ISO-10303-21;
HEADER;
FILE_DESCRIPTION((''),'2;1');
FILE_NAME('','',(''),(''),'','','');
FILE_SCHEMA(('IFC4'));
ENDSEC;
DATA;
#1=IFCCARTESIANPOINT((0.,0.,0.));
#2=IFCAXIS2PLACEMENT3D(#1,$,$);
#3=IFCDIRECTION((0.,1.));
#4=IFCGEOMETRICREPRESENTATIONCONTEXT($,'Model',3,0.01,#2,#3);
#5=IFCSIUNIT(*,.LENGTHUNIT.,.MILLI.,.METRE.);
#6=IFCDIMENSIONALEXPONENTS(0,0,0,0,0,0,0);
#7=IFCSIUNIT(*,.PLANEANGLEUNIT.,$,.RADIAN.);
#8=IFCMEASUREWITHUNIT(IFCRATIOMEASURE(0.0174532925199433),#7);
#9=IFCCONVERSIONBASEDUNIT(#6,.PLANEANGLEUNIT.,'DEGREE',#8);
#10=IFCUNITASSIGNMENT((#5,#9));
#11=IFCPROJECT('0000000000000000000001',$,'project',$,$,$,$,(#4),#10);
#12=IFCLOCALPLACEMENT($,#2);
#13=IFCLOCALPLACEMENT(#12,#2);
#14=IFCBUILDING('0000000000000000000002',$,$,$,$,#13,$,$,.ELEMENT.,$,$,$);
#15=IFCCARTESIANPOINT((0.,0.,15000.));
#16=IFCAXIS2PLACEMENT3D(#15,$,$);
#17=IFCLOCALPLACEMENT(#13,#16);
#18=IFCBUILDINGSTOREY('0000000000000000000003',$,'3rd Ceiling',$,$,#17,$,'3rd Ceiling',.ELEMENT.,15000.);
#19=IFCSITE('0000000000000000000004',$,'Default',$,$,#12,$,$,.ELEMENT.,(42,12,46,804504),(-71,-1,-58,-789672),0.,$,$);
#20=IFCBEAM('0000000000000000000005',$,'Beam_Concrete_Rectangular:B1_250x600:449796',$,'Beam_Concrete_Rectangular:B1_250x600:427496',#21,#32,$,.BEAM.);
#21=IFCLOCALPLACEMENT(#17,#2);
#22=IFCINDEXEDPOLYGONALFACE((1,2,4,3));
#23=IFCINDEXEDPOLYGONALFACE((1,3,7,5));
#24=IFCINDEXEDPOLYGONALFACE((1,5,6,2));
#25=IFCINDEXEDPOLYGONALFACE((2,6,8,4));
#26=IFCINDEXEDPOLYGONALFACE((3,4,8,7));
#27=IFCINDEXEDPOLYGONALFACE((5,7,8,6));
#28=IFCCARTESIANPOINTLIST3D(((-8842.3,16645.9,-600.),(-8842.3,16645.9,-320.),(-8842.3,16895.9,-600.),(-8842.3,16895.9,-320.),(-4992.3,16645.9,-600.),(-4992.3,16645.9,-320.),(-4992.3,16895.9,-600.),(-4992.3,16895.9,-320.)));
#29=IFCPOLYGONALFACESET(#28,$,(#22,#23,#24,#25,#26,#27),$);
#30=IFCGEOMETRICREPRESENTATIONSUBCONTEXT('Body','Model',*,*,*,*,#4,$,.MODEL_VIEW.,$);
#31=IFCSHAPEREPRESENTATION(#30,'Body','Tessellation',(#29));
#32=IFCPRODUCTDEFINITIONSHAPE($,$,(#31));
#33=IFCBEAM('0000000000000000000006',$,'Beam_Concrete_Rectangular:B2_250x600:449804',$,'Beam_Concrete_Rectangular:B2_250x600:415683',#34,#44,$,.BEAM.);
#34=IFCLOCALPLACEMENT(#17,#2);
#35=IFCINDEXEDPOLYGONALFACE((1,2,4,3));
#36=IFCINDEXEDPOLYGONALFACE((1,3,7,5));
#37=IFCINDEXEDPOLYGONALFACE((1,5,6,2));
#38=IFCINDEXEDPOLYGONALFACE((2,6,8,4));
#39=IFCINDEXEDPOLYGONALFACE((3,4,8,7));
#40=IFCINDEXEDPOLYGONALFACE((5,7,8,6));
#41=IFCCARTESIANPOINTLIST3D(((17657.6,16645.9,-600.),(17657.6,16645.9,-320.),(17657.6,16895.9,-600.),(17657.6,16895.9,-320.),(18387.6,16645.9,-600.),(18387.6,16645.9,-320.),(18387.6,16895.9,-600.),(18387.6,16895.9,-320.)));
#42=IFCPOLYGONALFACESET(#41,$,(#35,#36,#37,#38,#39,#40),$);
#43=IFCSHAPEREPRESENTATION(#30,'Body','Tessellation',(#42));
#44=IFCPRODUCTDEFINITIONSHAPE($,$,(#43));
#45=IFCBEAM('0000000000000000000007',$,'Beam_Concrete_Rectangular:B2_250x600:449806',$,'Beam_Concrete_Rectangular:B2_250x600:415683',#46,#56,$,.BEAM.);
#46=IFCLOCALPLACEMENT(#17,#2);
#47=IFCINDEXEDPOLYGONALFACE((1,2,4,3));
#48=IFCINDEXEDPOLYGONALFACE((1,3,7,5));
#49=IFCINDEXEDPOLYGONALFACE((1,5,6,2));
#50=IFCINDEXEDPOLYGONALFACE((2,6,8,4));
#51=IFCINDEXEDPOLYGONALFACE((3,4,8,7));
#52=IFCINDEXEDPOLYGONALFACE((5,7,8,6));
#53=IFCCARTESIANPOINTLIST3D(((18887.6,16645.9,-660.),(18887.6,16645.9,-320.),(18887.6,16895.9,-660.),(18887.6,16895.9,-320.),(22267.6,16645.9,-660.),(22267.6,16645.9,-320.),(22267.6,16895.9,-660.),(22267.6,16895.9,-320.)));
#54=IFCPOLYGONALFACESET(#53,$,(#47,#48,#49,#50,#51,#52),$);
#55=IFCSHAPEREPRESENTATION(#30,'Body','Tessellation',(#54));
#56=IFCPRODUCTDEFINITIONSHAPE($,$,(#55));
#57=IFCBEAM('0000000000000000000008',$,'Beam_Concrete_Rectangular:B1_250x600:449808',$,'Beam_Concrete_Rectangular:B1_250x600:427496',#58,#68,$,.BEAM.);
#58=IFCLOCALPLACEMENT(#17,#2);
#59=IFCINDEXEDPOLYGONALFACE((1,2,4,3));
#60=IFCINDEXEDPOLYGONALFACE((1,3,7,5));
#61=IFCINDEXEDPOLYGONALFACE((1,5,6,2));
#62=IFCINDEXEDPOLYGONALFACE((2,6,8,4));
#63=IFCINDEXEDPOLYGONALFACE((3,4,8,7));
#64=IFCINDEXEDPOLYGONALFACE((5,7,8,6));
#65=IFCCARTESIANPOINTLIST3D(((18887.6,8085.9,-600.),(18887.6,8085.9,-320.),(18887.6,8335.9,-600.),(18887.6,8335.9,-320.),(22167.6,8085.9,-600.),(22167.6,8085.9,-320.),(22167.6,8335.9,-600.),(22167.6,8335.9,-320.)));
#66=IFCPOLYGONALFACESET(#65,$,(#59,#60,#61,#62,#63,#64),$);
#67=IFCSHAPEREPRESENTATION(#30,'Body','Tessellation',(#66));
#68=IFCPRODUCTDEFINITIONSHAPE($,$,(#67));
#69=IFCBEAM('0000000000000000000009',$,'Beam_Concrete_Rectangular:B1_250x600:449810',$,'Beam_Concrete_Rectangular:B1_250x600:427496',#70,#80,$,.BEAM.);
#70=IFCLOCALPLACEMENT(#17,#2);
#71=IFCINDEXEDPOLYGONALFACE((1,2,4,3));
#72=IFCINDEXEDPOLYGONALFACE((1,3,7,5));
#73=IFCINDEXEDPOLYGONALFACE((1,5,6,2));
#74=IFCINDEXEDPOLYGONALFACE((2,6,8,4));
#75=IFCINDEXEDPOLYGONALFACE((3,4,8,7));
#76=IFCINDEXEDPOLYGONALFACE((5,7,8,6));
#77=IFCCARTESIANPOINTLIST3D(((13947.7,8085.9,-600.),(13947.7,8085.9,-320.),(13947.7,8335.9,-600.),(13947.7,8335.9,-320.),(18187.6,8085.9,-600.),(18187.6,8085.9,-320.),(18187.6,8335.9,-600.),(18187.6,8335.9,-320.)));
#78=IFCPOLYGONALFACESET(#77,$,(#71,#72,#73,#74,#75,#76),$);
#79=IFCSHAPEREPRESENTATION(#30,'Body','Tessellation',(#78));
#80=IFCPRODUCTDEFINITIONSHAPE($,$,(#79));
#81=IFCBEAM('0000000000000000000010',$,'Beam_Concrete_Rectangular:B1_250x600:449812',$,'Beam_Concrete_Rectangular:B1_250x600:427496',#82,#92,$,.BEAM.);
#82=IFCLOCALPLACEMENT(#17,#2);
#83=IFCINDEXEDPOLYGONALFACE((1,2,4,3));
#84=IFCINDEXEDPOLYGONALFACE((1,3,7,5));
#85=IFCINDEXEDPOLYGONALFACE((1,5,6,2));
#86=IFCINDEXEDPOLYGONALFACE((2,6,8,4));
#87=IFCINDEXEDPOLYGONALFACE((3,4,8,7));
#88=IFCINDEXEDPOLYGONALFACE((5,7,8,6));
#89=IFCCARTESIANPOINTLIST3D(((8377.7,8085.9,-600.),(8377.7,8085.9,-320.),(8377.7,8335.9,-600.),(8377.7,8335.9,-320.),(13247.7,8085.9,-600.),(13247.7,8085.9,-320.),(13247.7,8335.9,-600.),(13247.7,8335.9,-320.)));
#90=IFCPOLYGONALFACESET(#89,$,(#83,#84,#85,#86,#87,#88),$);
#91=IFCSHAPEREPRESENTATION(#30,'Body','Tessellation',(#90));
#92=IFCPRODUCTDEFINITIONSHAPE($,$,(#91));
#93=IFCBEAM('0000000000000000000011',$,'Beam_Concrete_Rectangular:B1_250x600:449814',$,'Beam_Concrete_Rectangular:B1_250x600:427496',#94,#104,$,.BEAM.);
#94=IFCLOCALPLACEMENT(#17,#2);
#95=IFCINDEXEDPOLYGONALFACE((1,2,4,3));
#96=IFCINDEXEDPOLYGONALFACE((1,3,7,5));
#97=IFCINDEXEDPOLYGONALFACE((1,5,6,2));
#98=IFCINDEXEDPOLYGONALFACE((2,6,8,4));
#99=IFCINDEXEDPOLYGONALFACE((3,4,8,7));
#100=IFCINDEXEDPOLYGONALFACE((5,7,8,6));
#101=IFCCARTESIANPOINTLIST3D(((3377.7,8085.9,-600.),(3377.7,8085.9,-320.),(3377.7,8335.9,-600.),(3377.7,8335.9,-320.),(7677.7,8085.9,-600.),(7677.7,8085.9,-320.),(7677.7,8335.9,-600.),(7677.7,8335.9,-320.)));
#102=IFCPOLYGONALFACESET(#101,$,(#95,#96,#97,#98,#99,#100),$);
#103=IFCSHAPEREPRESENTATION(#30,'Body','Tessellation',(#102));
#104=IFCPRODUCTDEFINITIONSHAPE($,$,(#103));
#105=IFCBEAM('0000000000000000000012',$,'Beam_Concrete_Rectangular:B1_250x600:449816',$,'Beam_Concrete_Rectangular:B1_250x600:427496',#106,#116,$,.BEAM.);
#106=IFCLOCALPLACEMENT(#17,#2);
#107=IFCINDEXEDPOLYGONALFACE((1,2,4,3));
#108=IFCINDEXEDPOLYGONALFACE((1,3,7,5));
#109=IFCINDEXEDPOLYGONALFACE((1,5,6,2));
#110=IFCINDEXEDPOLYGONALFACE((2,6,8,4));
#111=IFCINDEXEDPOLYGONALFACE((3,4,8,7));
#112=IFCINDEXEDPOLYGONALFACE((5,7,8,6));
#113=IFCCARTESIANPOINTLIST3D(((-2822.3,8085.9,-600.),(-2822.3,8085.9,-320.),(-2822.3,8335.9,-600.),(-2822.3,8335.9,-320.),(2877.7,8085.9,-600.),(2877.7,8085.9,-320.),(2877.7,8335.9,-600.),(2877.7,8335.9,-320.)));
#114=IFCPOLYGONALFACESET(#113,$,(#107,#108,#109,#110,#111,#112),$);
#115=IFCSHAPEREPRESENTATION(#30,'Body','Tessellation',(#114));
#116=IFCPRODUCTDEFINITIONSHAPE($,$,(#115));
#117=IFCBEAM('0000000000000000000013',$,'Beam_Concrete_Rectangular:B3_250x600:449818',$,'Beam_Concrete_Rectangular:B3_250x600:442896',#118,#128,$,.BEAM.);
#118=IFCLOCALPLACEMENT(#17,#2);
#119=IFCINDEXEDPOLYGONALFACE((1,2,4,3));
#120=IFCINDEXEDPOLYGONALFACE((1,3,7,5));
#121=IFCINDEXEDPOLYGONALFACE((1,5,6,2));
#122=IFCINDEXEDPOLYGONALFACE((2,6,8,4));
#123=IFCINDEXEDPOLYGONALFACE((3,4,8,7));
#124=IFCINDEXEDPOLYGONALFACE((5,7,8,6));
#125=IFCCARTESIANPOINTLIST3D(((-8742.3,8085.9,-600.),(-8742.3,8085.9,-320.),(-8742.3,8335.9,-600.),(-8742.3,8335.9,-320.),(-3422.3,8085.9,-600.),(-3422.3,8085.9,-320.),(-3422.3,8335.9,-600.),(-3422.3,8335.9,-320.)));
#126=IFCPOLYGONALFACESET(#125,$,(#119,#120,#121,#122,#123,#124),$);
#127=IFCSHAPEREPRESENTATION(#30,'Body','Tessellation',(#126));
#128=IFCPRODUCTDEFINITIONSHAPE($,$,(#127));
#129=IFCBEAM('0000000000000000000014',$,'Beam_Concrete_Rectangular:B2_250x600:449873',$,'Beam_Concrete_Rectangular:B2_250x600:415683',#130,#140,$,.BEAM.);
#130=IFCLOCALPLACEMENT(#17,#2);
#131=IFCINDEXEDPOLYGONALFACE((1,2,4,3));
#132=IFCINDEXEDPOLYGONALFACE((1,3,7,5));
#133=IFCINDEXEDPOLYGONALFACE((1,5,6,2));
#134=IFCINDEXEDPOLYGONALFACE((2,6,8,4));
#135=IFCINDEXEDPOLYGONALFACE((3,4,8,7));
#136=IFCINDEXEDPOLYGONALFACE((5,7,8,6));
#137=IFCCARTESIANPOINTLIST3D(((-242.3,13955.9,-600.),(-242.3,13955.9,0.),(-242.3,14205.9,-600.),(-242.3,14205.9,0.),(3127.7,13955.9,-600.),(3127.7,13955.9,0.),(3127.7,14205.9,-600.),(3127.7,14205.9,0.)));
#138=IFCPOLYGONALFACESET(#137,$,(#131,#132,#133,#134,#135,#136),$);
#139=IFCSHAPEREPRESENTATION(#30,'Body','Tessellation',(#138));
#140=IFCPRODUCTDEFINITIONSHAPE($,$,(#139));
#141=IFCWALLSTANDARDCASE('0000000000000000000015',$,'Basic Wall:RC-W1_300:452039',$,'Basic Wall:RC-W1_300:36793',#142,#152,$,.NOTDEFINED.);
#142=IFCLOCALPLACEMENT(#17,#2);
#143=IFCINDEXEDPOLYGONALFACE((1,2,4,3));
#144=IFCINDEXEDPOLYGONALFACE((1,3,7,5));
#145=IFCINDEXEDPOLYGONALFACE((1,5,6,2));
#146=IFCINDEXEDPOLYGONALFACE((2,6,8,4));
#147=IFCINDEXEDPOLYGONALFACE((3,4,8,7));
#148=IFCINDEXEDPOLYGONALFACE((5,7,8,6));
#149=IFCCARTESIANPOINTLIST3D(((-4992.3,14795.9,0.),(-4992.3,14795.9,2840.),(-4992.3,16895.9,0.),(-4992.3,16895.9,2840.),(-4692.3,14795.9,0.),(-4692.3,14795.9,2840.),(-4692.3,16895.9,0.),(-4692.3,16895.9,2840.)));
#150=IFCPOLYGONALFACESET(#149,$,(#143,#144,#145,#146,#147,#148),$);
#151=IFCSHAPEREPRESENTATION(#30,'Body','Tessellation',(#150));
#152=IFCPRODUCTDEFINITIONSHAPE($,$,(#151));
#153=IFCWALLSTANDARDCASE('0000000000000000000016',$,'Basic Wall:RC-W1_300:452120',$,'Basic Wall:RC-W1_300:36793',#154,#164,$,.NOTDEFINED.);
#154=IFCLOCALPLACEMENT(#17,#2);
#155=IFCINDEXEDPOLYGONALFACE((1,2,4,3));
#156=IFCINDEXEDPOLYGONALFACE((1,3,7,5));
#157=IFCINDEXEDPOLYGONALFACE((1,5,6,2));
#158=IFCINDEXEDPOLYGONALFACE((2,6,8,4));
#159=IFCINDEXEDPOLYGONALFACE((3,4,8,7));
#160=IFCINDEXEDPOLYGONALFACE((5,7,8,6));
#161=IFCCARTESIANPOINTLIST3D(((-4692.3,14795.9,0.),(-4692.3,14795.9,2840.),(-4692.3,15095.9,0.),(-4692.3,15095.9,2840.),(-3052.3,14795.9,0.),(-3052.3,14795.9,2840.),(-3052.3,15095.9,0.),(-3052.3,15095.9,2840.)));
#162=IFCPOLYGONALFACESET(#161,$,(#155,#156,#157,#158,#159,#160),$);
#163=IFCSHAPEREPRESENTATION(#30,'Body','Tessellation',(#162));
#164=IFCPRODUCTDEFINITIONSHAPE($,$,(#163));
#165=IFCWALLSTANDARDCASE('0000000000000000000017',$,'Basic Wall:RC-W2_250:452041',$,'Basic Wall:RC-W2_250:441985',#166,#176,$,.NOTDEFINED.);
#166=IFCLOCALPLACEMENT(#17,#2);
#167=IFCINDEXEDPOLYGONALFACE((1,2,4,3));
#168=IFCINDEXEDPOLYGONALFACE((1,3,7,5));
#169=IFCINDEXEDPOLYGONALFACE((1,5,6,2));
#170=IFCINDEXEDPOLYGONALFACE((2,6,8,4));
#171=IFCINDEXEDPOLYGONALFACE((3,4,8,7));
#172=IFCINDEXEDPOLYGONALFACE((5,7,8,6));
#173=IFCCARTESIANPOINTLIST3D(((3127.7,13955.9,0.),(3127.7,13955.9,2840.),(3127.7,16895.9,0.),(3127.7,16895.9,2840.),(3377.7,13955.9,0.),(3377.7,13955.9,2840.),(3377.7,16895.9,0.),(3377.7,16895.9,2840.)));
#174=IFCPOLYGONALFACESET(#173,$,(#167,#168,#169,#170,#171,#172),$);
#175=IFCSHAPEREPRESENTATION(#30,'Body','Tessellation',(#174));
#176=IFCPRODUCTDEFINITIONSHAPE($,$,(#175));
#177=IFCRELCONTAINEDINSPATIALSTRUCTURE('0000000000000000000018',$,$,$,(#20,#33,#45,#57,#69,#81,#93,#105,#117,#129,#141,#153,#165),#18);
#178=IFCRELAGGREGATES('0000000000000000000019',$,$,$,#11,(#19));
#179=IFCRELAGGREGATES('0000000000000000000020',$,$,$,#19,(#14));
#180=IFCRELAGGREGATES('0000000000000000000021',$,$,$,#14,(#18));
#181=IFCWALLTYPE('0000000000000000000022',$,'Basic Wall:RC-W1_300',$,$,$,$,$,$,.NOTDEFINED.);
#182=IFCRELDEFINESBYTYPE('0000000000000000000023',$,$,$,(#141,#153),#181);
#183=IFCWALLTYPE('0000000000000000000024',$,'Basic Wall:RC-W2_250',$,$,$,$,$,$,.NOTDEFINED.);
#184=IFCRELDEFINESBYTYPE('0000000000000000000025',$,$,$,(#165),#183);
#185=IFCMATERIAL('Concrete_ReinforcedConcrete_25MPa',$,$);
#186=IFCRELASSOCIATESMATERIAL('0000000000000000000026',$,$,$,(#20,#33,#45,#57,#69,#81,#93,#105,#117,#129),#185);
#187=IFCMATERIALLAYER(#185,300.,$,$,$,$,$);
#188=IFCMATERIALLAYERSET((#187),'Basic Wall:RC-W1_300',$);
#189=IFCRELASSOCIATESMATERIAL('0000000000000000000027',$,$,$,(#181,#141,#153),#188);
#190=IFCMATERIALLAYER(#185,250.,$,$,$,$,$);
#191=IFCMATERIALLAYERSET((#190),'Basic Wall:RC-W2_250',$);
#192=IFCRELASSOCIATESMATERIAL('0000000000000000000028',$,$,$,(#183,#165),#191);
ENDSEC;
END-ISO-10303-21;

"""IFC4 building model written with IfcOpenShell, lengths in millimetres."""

from ifc_helpers import new_model, entity, si_unit, converted_unit, direction, frame, frame_2d, origin, origin_2d_with_axis, place, context, subcontext, project, spatial, polyline, rectangle, extrude, clip, bounded_halfspace, material, layer, layer_set, layer_usage, type_object, element, save


model = new_model("IFC4")

# Units and contexts
model_context = context("Model", 3, precision=0.01, world=origin(), true_north=direction((0.0, 1.0)))
body_context = subcontext(model_context, "Body", "Model", "MODEL_VIEW")
ifc_project = project(units=[si_unit("LENGTHUNIT", "METRE", prefix="MILLI"), converted_unit("PLANEANGLEUNIT", "DEGREE", entity("IfcRatioMeasure", 0.0174532925199433), si_unit("PLANEANGLEUNIT", "RADIAN"), dimensions=[0, 0, 0, 0, 0, 0, 0])], contexts=[model_context])

# Site, building, storey
site_placement = place(None, origin())
site = spatial("IfcSite", under=ifc_project, at=site_placement, Name="Default", CompositionType="ELEMENT", RefLatitude=(42, 12, 46, 804504), RefLongitude=(-71, -1, -58, -789672), RefElevation=0.0)
building_placement = place(site_placement, origin())
building = spatial("IfcBuilding", under=site, at=building_placement, CompositionType="ELEMENT")
storey_placement = place(building_placement, frame((0.0, 0.0, 15000.0)))
storey = spatial("IfcBuildingStorey", under=building, at=storey_placement, Name="3rd Ceiling", LongName="3rd Ceiling", CompositionType="ELEMENT", Elevation=15000.0)

# Shared definitions
ifc_material = material(Name="Concrete_ReinforcedConcrete_25MPa")

# Beams
beam_1_placement = place(storey_placement, frame((-9042.3, 16645.9, 0.0)))
element("IfcBeam", 1, at=beam_1_placement, inside=storey, material=ifc_material, Name="Beam_Concrete_Rectangular:B1_250x600:449796", ObjectType="Beam_Concrete_Rectangular:B1_250x600:427496", PredefinedType="BEAM", context=body_context, shape_type="SweptSolid", body=[
    extrude(rectangle(XDim=280.0, YDim=250.0, at=origin_2d_with_axis()), frame((200.0, 125.0, -460.0), z_axis=(1.0, 0.0, 0.0), x_axis=(0.0, 0.0, -1.0)), (0.0, 0.0, 1.0), 3850.0),
])
beam_2_placement = place(storey_placement, frame((18637.6, 16895.9, 0.0), z_axis=(0.0, 0.0, 1.0), x_axis=(-1.0, 0.0, 0.0)))
element("IfcBeam", 2, at=beam_2_placement, inside=storey, material=ifc_material, Name="Beam_Concrete_Rectangular:B2_250x600:449804", ObjectType="Beam_Concrete_Rectangular:B2_250x600:415683", PredefinedType="BEAM", context=body_context, shape_type="SweptSolid", body=[
    extrude(rectangle(XDim=280.0, YDim=250.0, at=origin_2d_with_axis()), frame((250.0, 125.0, -460.0), z_axis=(1.0, 0.0, 0.0), x_axis=(0.0, 0.0, -1.0)), (0.0, 0.0, 1.0), 730.0),
])
beam_3_placement = place(storey_placement, frame((22467.6, 16895.9, 0.0), z_axis=(0.0, 0.0, 1.0), x_axis=(-1.0, 0.0, 0.0)))
element("IfcBeam", 3, at=beam_3_placement, inside=storey, material=ifc_material, Name="Beam_Concrete_Rectangular:B2_250x600:449806", ObjectType="Beam_Concrete_Rectangular:B2_250x600:415683", PredefinedType="BEAM", context=body_context, shape_type="SweptSolid", body=[
    extrude(rectangle(XDim=340.0, YDim=250.0, at=origin_2d_with_axis()), frame((200.0, 125.0, -490.0), z_axis=(1.0, 0.0, 0.0), x_axis=(0.0, 0.0, -1.0)), (0.0, 0.0, 1.0), 3380.0),
])
beam_4_placement = place(storey_placement, frame((18537.6, 8085.9, 0.0)))
element("IfcBeam", 4, at=beam_4_placement, inside=storey, material=ifc_material, Name="Beam_Concrete_Rectangular:B1_250x600:449808", ObjectType="Beam_Concrete_Rectangular:B1_250x600:427496", PredefinedType="BEAM", context=body_context, shape_type="SweptSolid", body=[
    extrude(rectangle(XDim=280.0, YDim=250.0, at=frame_2d((0.0, 0.0), x_axis=(1.0, 0.0))), frame((350.0, 125.0, -460.0), z_axis=(1.0, 0.0, 0.0), x_axis=(0.0, 0.0, -1.0)), (0.0, 0.0, 1.0), 3280.0),
])
beam_5_placement = place(storey_placement, frame((13597.7, 8085.9, 0.0)))
element("IfcBeam", 5, at=beam_5_placement, inside=storey, material=ifc_material, Name="Beam_Concrete_Rectangular:B1_250x600:449810", ObjectType="Beam_Concrete_Rectangular:B1_250x600:427496", PredefinedType="BEAM", context=body_context, shape_type="SweptSolid", body=[
    extrude(rectangle(XDim=280.0, YDim=250.0, at=frame_2d((0.0, 0.0), x_axis=(1.0, 0.0))), frame((350.0, 125.0, -460.0), z_axis=(1.0, 0.0, 0.0), x_axis=(0.0, 0.0, -1.0)), (0.0, 0.0, 1.0), 4240.0),
])
beam_6_placement = place(storey_placement, frame((8027.7, 8085.9, 0.0)))
element("IfcBeam", 6, at=beam_6_placement, inside=storey, material=ifc_material, Name="Beam_Concrete_Rectangular:B1_250x600:449812", ObjectType="Beam_Concrete_Rectangular:B1_250x600:427496", PredefinedType="BEAM", context=body_context, shape_type="SweptSolid", body=[
    extrude(rectangle(XDim=280.0, YDim=250.0, at=frame_2d((0.0, 0.0), x_axis=(1.0, 0.0))), frame((350.0, 125.0, -460.0), z_axis=(1.0, 0.0, 0.0), x_axis=(0.0, 0.0, -1.0)), (0.0, 0.0, 1.0), 4870.0),
])
beam_7_placement = place(storey_placement, frame((3127.7, 8085.9, 0.0)))
element("IfcBeam", 7, at=beam_7_placement, inside=storey, material=ifc_material, Name="Beam_Concrete_Rectangular:B1_250x600:449814", ObjectType="Beam_Concrete_Rectangular:B1_250x600:427496", PredefinedType="BEAM", context=body_context, shape_type="SweptSolid", body=[
    extrude(rectangle(XDim=280.0, YDim=250.0, at=frame_2d((0.0, 0.0), x_axis=(1.0, 0.0))), frame((250.0, 125.0, -460.0), z_axis=(1.0, 0.0, 0.0), x_axis=(0.0, 0.0, -1.0)), (0.0, 0.0, 1.0), 4300.0),
])
beam_8_placement = place(storey_placement, frame((-3122.3, 8085.9, 0.0)))
element("IfcBeam", 8, at=beam_8_placement, inside=storey, material=ifc_material, Name="Beam_Concrete_Rectangular:B1_250x600:449816", ObjectType="Beam_Concrete_Rectangular:B1_250x600:427496", PredefinedType="BEAM", context=body_context, shape_type="SweptSolid", body=[
    extrude(rectangle(XDim=280.0, YDim=250.0, at=frame_2d((0.0, 0.0), x_axis=(1.0, 0.0))), frame((300.0, 125.0, -460.0), z_axis=(1.0, 0.0, 0.0), x_axis=(0.0, 0.0, -1.0)), (0.0, 0.0, 1.0), 5700.0),
])
beam_9_placement = place(storey_placement, frame((-8992.3, 8085.9, 0.0)))
element("IfcBeam", 9, at=beam_9_placement, inside=storey, material=ifc_material, Name="Beam_Concrete_Rectangular:B3_250x600:449818", ObjectType="Beam_Concrete_Rectangular:B3_250x600:442896", PredefinedType="BEAM", context=body_context, shape_type="SweptSolid", body=[
    extrude(rectangle(XDim=280.0, YDim=250.0, at=frame_2d((0.0, 0.0), x_axis=(1.0, 0.0))), frame((250.0, 125.0, -460.0), z_axis=(1.0, 0.0, 0.0), x_axis=(0.0, 0.0, -1.0)), (0.0, 0.0, 1.0), 5320.0),
])
beam_10_placement = place(storey_placement, frame((3252.7, 14205.9, 0.0), z_axis=(0.0, 0.0, 1.0), x_axis=(-1.0, 0.0, 0.0)))
element("IfcBeam", 10, at=beam_10_placement, inside=storey, material=ifc_material, Name="Beam_Concrete_Rectangular:B2_250x600:449873", ObjectType="Beam_Concrete_Rectangular:B2_250x600:415683", PredefinedType="BEAM", context=body_context, shape_type="SweptSolid", body=[
    extrude(rectangle(XDim=600.0, YDim=250.0, at=frame_2d((0.0, 0.0), x_axis=(1.0, 0.0))), frame((125.0, 125.0, -300.0), z_axis=(1.0, 0.0, 0.0), x_axis=(0.0, 0.0, -1.0)), (0.0, 0.0, 1.0), 3370.0),
])

# Walls
ifc_layer_1 = layer(ifc_material, 300.0)
ifc_layer_set_1 = layer_set([ifc_layer_1], Name="Basic Wall:RC-W1_300")
ifc_layer_usage_1 = layer_usage(ifc_layer_set_1, "AXIS2", "NEGATIVE", 150.0)
wall_type_1 = type_object("IfcWallType", Name="Basic Wall:RC-W1_300", PredefinedType="NOTDEFINED", material=ifc_layer_set_1)
wall_1_placement = place(storey_placement, frame((-4842.3, 16895.9, 0.0), z_axis=(0.0, 0.0, 1.0), x_axis=(0.0, -1.0, 0.0)))
element("IfcWallStandardCase", 11, at=wall_1_placement, inside=storey, type_object=wall_type_1, material=ifc_layer_usage_1, Name="Basic Wall:RC-W1_300:452039", ObjectType="Basic Wall:RC-W1_300:36793", PredefinedType="NOTDEFINED", context=body_context, shape_type="Clipping", body=[
    clip(extrude(rectangle(XDim=2100.0, YDim=300.0, at=frame_2d((1050.0, 0.0), x_axis=(-1.0, 0.0))), origin(), (0.0, 0.0, 1.0), 2840.0), bounded_halfspace(frame((0.0, -150.0, 2840.0), z_axis=(0.0, 0.0, -1.0), x_axis=(1.0, 0.0, 0.0)), True, frame((0.0, -150.0, 2840.0)), polyline([(0.0, 0.0), (2100.0, 0.0), (2100.0, 300.0), (1800.0, 300.0), (0.0, 300.0), (0.0, 0.0)]))),
])
ifc_layer_usage_2 = layer_usage(ifc_layer_set_1, "AXIS2", "NEGATIVE", 150.0)
wall_2_placement = place(storey_placement, frame((-4692.3, 14945.9, 0.0)))
element("IfcWallStandardCase", 12, at=wall_2_placement, inside=storey, type_object=wall_type_1, material=ifc_layer_usage_2, Name="Basic Wall:RC-W1_300:452120", ObjectType="Basic Wall:RC-W1_300:36793", PredefinedType="NOTDEFINED", context=body_context, shape_type="Clipping", body=[
    clip(extrude(rectangle(XDim=1640.0, YDim=300.0, at=frame_2d((820.0, 0.0), x_axis=(-1.0, 0.0))), origin(), (0.0, 0.0, 1.0), 2840.0), bounded_halfspace(frame((0.0, -150.0, 2840.0), z_axis=(0.0, 0.0, -1.0), x_axis=(0.0, -1.0, 0.0)), True, frame((0.0, -150.0, 2840.0)), polyline([(0.0, 0.0), (1640.0, 0.0), (1640.0, 300.0), (0.0, 300.0), (0.0, 0.0)]))),
])
ifc_layer_2 = layer(ifc_material, 250.0)
ifc_layer_set_2 = layer_set([ifc_layer_2], Name="Basic Wall:RC-W2_250")
ifc_layer_usage_3 = layer_usage(ifc_layer_set_2, "AXIS2", "NEGATIVE", 125.0)
wall_type_2 = type_object("IfcWallType", Name="Basic Wall:RC-W2_250", PredefinedType="NOTDEFINED", material=ifc_layer_set_2)
wall_3_placement = place(storey_placement, frame((3252.7, 13955.9, 0.0), z_axis=(0.0, 0.0, 1.0), x_axis=(0.0, 1.0, 0.0)))
element("IfcWallStandardCase", 13, at=wall_3_placement, inside=storey, type_object=wall_type_2, material=ifc_layer_usage_3, Name="Basic Wall:RC-W2_250:452041", ObjectType="Basic Wall:RC-W2_250:441985", PredefinedType="NOTDEFINED", context=body_context, shape_type="Clipping", body=[
    clip(extrude(rectangle(XDim=2940.0, YDim=250.0, at=frame_2d((1470.0, 0.0), x_axis=(-1.0, 0.0))), origin(), (0.0, 0.0, 1.0), 2840.0), bounded_halfspace(frame((0.0, -125.0, 2840.0), z_axis=(0.0, 0.0, -1.0), x_axis=(-1.0, 0.0, 0.0)), True, frame((0.0, -125.0, 2840.0)), polyline([(0.0, 0.0), (2940.0, 0.0), (2940.0, 250.0), (0.0, 250.0), (0.0, 0.0)]))),
])

save(model, "model.ifc")
